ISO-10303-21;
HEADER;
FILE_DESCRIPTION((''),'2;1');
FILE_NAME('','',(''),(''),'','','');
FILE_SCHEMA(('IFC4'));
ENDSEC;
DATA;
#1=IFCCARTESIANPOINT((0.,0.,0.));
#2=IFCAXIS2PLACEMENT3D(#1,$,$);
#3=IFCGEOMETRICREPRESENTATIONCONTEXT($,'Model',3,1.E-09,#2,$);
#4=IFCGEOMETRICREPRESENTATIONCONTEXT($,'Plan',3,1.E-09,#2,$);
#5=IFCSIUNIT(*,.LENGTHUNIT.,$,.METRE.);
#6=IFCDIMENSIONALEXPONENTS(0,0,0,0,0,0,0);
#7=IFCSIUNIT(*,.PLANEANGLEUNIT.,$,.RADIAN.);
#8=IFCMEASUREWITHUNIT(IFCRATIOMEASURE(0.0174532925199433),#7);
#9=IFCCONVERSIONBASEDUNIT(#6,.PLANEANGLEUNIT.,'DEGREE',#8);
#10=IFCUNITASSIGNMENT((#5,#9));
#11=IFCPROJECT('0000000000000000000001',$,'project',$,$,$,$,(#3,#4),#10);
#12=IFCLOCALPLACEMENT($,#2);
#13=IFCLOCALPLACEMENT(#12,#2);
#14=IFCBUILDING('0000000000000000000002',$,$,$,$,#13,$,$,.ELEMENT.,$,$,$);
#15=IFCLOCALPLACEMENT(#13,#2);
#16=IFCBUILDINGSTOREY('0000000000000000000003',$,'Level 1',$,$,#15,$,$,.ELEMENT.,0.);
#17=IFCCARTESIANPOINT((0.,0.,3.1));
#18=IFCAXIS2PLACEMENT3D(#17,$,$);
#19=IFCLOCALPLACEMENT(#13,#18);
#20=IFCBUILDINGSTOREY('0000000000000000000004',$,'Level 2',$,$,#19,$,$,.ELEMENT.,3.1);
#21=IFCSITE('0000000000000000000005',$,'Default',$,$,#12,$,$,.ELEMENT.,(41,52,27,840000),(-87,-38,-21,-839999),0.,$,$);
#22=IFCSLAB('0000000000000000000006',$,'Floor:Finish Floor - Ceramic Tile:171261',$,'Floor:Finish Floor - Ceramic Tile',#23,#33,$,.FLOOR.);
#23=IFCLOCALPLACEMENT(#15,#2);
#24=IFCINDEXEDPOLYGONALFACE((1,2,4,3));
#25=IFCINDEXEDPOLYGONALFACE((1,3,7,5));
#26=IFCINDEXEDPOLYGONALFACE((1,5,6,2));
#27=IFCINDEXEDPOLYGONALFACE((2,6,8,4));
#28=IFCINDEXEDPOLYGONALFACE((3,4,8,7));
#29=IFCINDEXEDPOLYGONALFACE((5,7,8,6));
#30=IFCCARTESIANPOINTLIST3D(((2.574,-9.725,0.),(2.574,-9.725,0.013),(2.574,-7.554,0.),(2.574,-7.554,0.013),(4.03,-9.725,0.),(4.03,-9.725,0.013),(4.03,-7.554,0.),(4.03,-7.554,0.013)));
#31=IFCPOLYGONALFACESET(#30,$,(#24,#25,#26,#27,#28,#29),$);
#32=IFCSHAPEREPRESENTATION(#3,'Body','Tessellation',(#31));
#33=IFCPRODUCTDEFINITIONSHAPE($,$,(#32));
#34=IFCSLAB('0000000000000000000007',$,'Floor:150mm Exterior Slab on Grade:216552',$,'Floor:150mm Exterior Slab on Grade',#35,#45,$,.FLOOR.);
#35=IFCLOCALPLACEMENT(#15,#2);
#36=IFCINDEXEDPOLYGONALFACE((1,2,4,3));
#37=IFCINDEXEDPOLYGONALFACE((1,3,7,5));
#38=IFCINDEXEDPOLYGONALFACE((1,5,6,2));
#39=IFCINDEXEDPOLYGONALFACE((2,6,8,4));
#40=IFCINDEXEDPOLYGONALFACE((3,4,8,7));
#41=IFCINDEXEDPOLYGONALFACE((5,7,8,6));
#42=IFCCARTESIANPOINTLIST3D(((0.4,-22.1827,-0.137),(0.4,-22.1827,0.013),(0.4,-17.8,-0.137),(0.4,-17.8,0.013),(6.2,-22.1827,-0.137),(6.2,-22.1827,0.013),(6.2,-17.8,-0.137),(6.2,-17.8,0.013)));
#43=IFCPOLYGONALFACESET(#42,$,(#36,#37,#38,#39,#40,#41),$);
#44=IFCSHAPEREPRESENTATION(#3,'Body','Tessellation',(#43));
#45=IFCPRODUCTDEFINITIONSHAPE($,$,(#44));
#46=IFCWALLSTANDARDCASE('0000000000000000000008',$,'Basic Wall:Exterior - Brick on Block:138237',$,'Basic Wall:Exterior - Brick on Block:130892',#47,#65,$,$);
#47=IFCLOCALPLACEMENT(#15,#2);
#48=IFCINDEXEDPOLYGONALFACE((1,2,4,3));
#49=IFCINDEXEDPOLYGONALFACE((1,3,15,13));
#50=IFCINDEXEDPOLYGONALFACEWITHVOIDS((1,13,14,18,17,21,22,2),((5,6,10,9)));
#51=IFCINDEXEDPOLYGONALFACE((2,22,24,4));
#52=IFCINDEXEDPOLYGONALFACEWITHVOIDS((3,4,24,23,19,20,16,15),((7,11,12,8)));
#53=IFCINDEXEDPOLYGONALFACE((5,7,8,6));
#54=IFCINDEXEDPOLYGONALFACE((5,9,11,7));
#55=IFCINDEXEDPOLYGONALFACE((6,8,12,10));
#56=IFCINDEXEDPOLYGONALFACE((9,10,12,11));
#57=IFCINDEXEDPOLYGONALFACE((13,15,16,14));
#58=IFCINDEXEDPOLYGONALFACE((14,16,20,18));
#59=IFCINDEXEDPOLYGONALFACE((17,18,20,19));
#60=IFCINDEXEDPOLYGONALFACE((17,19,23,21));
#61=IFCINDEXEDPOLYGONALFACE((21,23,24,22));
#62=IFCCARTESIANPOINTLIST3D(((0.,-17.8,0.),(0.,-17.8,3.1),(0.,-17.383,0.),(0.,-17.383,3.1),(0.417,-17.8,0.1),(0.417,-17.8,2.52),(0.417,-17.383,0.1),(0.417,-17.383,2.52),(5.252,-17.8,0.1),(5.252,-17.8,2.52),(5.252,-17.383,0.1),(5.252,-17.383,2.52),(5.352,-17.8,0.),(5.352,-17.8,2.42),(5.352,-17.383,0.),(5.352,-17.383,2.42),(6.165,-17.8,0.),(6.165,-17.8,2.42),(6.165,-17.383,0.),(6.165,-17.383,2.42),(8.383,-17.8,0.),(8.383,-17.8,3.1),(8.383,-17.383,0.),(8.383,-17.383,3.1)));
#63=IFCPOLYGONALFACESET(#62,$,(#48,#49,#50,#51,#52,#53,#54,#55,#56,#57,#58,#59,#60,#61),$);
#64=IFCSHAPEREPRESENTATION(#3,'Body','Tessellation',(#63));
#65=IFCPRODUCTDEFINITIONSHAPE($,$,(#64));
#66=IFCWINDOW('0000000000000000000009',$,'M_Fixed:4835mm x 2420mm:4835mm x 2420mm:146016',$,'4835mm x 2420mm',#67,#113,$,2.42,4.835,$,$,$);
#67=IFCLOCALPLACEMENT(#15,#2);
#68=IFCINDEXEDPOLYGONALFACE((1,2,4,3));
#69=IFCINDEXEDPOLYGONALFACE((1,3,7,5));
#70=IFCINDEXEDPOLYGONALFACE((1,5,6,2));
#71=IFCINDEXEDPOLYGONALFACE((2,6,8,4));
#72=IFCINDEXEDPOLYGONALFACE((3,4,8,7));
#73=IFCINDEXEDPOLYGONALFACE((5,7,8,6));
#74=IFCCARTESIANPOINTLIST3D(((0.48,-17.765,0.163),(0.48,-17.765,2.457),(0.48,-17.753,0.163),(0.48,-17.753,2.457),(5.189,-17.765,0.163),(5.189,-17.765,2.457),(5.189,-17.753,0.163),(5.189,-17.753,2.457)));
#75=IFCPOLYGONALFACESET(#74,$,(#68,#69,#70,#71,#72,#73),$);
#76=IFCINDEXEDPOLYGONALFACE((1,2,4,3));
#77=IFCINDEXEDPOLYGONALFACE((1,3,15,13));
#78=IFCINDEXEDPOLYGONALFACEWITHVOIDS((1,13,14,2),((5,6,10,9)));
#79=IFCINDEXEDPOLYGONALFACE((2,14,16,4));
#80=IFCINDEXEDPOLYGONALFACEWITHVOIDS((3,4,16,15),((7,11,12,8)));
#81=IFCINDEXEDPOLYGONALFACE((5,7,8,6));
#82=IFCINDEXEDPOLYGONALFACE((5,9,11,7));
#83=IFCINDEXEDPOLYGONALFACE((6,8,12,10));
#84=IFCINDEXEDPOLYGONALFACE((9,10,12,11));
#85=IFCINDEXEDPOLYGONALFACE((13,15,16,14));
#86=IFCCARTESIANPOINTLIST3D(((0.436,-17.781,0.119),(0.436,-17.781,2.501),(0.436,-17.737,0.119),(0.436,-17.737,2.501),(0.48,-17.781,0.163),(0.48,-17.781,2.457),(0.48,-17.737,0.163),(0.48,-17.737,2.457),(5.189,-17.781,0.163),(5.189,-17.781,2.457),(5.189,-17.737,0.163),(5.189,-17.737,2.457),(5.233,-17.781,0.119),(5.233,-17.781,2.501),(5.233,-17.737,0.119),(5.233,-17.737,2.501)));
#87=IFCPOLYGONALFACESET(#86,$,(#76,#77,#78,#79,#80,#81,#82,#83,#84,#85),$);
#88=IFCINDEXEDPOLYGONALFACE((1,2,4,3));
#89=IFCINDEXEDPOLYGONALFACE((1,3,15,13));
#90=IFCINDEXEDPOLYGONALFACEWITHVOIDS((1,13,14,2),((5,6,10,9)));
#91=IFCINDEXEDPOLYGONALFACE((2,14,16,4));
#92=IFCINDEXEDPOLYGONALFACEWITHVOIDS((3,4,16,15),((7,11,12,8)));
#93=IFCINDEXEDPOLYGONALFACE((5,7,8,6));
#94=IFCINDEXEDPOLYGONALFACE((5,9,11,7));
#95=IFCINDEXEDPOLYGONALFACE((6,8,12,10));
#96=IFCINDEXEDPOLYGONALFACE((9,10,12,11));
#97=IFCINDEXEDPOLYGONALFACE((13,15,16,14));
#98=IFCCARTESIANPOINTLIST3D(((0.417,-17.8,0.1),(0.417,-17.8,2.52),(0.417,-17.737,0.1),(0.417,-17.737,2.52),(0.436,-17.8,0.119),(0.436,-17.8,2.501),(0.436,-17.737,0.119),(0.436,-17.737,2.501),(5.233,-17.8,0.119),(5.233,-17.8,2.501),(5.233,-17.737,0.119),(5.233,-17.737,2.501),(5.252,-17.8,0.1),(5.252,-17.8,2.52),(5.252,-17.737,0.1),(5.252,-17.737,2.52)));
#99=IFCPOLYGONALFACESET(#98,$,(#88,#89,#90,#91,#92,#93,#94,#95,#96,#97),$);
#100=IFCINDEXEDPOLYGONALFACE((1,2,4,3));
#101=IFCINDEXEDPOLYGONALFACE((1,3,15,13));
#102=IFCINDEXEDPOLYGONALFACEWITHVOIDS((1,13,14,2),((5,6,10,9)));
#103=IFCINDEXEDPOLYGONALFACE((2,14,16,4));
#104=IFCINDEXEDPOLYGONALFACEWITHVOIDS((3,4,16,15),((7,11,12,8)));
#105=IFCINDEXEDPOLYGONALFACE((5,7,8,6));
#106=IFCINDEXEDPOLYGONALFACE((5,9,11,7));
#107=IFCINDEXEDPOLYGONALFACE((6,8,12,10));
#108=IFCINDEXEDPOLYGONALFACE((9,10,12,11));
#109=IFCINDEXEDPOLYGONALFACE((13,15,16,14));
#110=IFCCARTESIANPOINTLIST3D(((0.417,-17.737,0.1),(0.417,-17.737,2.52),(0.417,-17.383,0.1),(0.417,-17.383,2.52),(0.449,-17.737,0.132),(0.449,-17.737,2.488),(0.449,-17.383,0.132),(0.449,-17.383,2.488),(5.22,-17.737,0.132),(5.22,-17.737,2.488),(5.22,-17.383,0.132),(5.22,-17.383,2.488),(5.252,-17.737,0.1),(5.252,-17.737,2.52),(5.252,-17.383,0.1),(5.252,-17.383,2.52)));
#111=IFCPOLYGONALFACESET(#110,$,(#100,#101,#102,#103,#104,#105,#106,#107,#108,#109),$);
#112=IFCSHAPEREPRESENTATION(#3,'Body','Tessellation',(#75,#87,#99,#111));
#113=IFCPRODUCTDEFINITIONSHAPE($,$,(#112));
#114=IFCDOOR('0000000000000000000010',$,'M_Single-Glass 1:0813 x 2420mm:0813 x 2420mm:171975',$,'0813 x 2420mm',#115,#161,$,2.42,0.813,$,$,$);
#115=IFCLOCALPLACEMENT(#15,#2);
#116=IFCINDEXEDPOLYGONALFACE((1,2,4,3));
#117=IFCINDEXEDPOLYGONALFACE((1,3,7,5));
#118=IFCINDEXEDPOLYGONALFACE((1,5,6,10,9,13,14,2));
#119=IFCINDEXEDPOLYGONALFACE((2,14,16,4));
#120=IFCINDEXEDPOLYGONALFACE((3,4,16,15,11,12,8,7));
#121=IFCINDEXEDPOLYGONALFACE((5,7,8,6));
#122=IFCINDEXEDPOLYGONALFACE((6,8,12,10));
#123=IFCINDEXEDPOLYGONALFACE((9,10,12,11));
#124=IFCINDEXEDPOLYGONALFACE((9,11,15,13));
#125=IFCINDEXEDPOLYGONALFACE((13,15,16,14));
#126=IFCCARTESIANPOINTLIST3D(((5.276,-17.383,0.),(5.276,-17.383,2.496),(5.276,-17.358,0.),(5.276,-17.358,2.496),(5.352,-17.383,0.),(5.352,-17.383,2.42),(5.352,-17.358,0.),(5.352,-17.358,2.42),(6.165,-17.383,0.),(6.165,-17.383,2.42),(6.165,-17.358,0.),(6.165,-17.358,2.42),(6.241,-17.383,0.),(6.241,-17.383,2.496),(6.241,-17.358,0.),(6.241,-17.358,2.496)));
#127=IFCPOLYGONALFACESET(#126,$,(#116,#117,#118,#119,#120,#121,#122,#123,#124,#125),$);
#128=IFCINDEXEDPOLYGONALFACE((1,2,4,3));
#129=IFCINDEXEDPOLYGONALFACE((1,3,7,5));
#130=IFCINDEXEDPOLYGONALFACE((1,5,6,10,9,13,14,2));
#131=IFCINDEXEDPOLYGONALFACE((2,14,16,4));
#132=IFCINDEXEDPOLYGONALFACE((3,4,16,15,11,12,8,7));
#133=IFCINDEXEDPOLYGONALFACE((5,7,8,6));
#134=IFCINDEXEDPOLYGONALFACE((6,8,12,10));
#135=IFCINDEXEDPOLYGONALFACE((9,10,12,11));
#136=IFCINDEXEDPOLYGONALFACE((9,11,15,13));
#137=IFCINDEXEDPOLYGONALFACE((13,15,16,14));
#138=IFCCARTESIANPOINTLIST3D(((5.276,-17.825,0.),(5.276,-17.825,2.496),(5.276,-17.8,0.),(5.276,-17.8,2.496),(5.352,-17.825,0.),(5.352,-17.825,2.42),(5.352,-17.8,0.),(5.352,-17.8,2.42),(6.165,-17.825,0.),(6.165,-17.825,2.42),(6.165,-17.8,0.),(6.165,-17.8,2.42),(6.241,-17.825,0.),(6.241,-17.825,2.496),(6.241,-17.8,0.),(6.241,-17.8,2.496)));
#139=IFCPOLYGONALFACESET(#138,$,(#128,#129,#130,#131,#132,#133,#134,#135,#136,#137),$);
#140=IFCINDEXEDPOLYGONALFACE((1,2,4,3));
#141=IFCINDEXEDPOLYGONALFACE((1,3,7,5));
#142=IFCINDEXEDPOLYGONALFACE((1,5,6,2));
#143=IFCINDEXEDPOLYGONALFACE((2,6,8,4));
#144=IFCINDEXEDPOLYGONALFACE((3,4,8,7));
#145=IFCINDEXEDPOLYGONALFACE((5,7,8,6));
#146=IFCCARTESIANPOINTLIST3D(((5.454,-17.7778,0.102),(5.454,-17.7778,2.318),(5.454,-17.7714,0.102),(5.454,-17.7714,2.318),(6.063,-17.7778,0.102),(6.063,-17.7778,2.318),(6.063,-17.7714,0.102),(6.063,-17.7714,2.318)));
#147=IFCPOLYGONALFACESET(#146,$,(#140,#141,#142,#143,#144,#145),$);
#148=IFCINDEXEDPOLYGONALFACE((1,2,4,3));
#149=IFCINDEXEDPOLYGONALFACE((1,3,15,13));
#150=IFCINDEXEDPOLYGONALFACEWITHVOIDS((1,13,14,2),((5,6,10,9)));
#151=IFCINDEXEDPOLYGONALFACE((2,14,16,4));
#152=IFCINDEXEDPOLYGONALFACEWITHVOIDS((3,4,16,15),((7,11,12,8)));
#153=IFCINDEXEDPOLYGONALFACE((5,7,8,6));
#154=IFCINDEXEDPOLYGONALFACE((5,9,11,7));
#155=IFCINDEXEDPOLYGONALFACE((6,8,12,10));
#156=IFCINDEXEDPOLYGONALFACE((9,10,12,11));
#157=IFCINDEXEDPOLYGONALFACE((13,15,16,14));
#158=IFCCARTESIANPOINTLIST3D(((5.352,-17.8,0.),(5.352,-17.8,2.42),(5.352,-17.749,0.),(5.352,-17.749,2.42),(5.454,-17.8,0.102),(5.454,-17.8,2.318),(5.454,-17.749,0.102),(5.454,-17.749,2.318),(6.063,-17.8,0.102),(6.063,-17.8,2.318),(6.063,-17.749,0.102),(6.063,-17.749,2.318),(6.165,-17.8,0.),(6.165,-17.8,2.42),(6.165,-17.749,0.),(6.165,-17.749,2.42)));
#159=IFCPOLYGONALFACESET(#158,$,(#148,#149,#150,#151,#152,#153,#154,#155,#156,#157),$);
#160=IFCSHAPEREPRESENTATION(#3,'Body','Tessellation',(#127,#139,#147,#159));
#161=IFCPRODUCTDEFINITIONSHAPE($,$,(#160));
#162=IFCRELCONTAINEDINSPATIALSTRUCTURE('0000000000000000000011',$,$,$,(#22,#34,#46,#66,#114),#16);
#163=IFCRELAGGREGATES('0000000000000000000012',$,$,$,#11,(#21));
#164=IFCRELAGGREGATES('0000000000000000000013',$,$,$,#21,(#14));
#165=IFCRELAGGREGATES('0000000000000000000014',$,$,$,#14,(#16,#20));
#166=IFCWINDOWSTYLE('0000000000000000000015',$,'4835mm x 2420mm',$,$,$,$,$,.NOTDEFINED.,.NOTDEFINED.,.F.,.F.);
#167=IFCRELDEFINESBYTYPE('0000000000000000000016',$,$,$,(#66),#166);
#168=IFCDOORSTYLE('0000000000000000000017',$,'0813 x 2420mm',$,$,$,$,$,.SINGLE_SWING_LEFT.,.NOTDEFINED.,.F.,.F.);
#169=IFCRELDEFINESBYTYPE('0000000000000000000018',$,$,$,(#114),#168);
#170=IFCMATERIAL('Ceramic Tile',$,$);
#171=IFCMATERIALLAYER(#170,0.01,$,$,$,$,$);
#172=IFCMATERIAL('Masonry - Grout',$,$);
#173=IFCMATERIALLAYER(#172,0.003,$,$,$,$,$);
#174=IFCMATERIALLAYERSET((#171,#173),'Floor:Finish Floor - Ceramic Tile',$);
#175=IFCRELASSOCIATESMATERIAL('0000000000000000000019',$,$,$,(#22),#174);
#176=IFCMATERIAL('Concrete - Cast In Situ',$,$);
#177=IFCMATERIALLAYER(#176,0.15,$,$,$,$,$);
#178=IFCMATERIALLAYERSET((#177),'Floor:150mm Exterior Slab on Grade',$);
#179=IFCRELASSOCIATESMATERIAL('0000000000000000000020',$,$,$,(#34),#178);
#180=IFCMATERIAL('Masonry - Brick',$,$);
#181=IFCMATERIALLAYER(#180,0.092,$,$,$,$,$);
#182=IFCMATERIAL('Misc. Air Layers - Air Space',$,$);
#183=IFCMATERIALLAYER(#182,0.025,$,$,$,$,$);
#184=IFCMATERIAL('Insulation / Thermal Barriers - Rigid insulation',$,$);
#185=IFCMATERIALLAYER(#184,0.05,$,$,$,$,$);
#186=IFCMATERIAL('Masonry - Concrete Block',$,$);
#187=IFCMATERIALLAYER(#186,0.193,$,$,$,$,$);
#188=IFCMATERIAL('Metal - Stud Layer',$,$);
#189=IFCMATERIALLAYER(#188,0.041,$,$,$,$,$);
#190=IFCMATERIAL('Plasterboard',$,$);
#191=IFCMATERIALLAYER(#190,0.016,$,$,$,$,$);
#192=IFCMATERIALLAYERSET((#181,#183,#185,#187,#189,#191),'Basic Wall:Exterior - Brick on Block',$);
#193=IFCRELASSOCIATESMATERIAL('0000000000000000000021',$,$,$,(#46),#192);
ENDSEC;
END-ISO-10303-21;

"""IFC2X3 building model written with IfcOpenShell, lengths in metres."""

from ifc_helpers import new_model, entity, si_unit, converted_unit, frame, frame_2d, origin, origin_2d_with_axis, place, context, project, spatial, polyline, rectangle, outline, extrude, source, transform, mapped, material, layer, layer_set, layer_usage, type_object, type_shapes, element, fill, save


model = new_model("IFC2X3")

# Units and contexts
model_context = context("Model", 3, precision=1e-09, world=origin())
plan_context = context("Plan", 3, precision=1e-09, world=origin())
ifc_project = project(units=[si_unit("LENGTHUNIT", "METRE"), converted_unit("PLANEANGLEUNIT", "DEGREE", entity("IfcRatioMeasure", 0.0174532925199433), si_unit("PLANEANGLEUNIT", "RADIAN"), dimensions=[0, 0, 0, 0, 0, 0, 0])], contexts=[model_context, plan_context])

# Site, building, storey
site_placement = place(None, origin())
site = spatial("IfcSite", under=ifc_project, at=site_placement, Name="Default", CompositionType="ELEMENT", RefLatitude=(41, 52, 27, 840000), RefLongitude=(-87, -38, -21, -839999), RefElevation=0.0)
building_placement = place(site_placement, origin())
building = spatial("IfcBuilding", under=site, at=building_placement, CompositionType="ELEMENT")
storey_1_placement = place(building_placement, origin())
storey_1 = spatial("IfcBuildingStorey", under=building, at=storey_1_placement, Name="Level 1", CompositionType="ELEMENT", Elevation=0.0)

# Slabs
ifc_material_1 = material(Name="Ceramic Tile")
ifc_layer_1 = layer(ifc_material_1, 0.01)
ifc_material_2 = material(Name="Masonry - Grout")
ifc_layer_2 = layer(ifc_material_2, 0.003)
ifc_layer_set_1 = layer_set([ifc_layer_1, ifc_layer_2], Name="Floor:Finish Floor - Ceramic Tile")
ifc_layer_usage_1 = layer_usage(ifc_layer_set_1, "AXIS3", "POSITIVE", 0.0)
slab_1_placement = place(storey_1_placement, frame((2.574, -9.725, 0.0)))
element("IfcSlab", 1, at=slab_1_placement, inside=storey_1, material=ifc_layer_usage_1, Name="Floor:Finish Floor - Ceramic Tile:171261", ObjectType="Floor:Finish Floor - Ceramic Tile", PredefinedType="FLOOR", context=model_context, shape_type="SweptSolid", body=[
    extrude(rectangle(XDim=2.171, YDim=1.456, at=frame_2d((0.0, 0.0), x_axis=(0.0, -1.0))), frame((0.728, 1.0855, 0.013), z_axis=(0.0, 0.0, -1.0), x_axis=(-1.0, 0.0, 0.0)), (0.0, 0.0, 1.0), 0.013),
])
ifc_material_3 = material(Name="Concrete - Cast In Situ")
ifc_layer_3 = layer(ifc_material_3, 0.15)
ifc_layer_set_2 = layer_set([ifc_layer_3], Name="Floor:150mm Exterior Slab on Grade")
ifc_layer_usage_2 = layer_usage(ifc_layer_set_2, "AXIS3", "POSITIVE", 0.0)
slab_2_placement = place(storey_1_placement, frame((0.4, -22.1827, -0.137)))
element("IfcSlab", 2, at=slab_2_placement, inside=storey_1, material=ifc_layer_usage_2, Name="Floor:150mm Exterior Slab on Grade:216552", ObjectType="Floor:150mm Exterior Slab on Grade", PredefinedType="FLOOR", context=model_context, shape_type="SweptSolid", body=[
    extrude(rectangle(XDim=5.8, YDim=4.3827, at=origin_2d_with_axis()), frame((2.9, 2.1914, 0.15), z_axis=(0.0, 0.0, -1.0), x_axis=(-1.0, 0.0, 0.0)), (0.0, 0.0, 1.0), 0.15),
])

# Wall, openings, window, door
ifc_material_4 = material(Name="Masonry - Brick")
ifc_layer_4 = layer(ifc_material_4, 0.092)
ifc_material_5 = material(Name="Misc. Air Layers - Air Space")
ifc_layer_5 = layer(ifc_material_5, 0.025)
ifc_material_6 = material(Name="Insulation / Thermal Barriers - Rigid insulation")
ifc_layer_6 = layer(ifc_material_6, 0.05)
ifc_material_7 = material(Name="Masonry - Concrete Block")
ifc_layer_7 = layer(ifc_material_7, 0.193)
ifc_material_8 = material(Name="Metal - Stud Layer")
ifc_layer_8 = layer(ifc_material_8, 0.041)
ifc_material_9 = material(Name="Plasterboard")
ifc_layer_9 = layer(ifc_material_9, 0.016)
ifc_layer_set_3 = layer_set([ifc_layer_4, ifc_layer_5, ifc_layer_6, ifc_layer_7, ifc_layer_8, ifc_layer_9], Name="Basic Wall:Exterior - Brick on Block")
ifc_layer_usage_3 = layer_usage(ifc_layer_set_3, "AXIS2", "NEGATIVE", 0.2085)
wall_1_placement = place(storey_1_placement, frame((8.383, -17.5915, 0.0), z_axis=(0.0, 0.0, 1.0), x_axis=(-1.0, 0.0, 0.0)))
wall_1 = element("IfcWallStandardCase", 3, at=wall_1_placement, inside=storey_1, material=ifc_layer_usage_3, Name="Basic Wall:Exterior - Brick on Block:138237", ObjectType="Basic Wall:Exterior - Brick on Block:130892", context=model_context, shape_type="SweptSolid", body=[
    extrude(rectangle(XDim=8.383, YDim=0.417, at=frame_2d((4.1915, 0.0), x_axis=(-1.0, 0.0))), origin(), (0.0, 0.0, 1.0), 3.1),
])
opening_1_placement = place(wall_1_placement, frame((3.131, -0.2085, 0.1)))
opening_1 = element("IfcOpeningElement", 4, at=opening_1_placement, cuts=wall_1, ObjectType="Opening", context=model_context, shape_type="SweptSolid", body=[
    extrude(rectangle(XDim=2.42, YDim=4.835, at=frame_2d((1.21, 2.4175), x_axis=(1.0, 0.0))), frame((0.0, 0.0, 0.0), z_axis=(0.0, 1.0, 0.0), x_axis=(0.0, 0.0, 1.0)), (0.0, 0.0, 1.0), 0.417),
])
opening_2_placement = place(wall_1_placement, frame((2.218, -0.2085, 0.0)))
opening_2 = element("IfcOpeningElement", 5, at=opening_2_placement, cuts=wall_1, ObjectType="Opening", context=model_context, shape_type="SweptSolid", body=[
    extrude(rectangle(XDim=0.813, YDim=2.42, at=frame_2d((1.21, 0.4065), x_axis=(0.0, -1.0))), frame((0.0, 0.0, 0.0), z_axis=(0.0, 1.0, 0.0), x_axis=(0.0, 0.0, 1.0)), (0.0, 0.0, 1.0), 0.417),
])
window_style_1 = type_object("IfcWindowStyle", Name="4835mm x 2420mm", ConstructionType="NOTDEFINED", OperationType="NOTDEFINED", ParameterTakesPrecedence=False, Sizeable=False)
shared_shape_1 = source(origin(), model_context, "Body", "SweptSolid", [
    extrude(rectangle(XDim=0.012, YDim=4.709, at=origin_2d_with_axis()), frame((2.4175, 0.376, 0.063), z_axis=(0.0, 0.0, 1.0), x_axis=(0.0, -1.0, 0.0)), (0.0, 0.0, 1.0), 2.294),
    extrude(outline(polyline([(-2.3985, -1.191), (2.3985, -1.191), (2.3985, 1.191), (-2.3985, 1.191), (-2.3985, -1.191)]), holes=[polyline([(-2.3545, -1.147), (-2.3545, 1.147), (2.3545, 1.147), (2.3545, -1.147), (-2.3545, -1.147)])]), frame((2.4175, 0.354, 1.21), z_axis=(0.0, 1.0, 0.0), x_axis=(1.0, 0.0, 0.0)), (0.0, 0.0, 1.0), 0.044),
    extrude(outline(polyline([(-2.4175, -1.21), (2.4175, -1.21), (2.4175, 1.21), (-2.4175, 1.21), (-2.4175, -1.21)]), holes=[polyline([(-2.3985, -1.191), (-2.3985, 1.191), (2.3985, 1.191), (2.3985, -1.191), (-2.3985, -1.191)])]), frame((2.4175, 0.354, 1.21), z_axis=(0.0, 1.0, 0.0), x_axis=(1.0, 0.0, 0.0)), (0.0, 0.0, 1.0), 0.063),
    extrude(outline(polyline([(-2.4175, -1.21), (2.4175, -1.21), (2.4175, 1.21), (-2.4175, 1.21), (-2.4175, -1.21)]), holes=[polyline([(-2.3855, -1.178), (-2.3855, 1.178), (2.3855, 1.178), (2.3855, -1.178), (-2.3855, -1.178)])]), frame((2.4175, 0.0, 1.21), z_axis=(0.0, 1.0, 0.0), x_axis=(1.0, 0.0, 0.0)), (0.0, 0.0, 1.0), 0.354),
])
type_shapes(window_style_1, [shared_shape_1])
window_1_placement = place(opening_1_placement, origin())
window_1 = element("IfcWindow", 6, at=window_1_placement, inside=storey_1, type_object=window_style_1, Name="M_Fixed:4835mm x 2420mm:4835mm x 2420mm:146016", ObjectType="4835mm x 2420mm", OverallHeight=2.42, OverallWidth=4.835, context=model_context, shape_type="MappedRepresentation", body=[
    mapped(shared_shape_1, transform((0.0, 0.0, 0.0), scale=1.0)),
])
fill(opening_1, window_1)
door_style_1 = type_object("IfcDoorStyle", Name="0813 x 2420mm", ConstructionType="NOTDEFINED", OperationType="SINGLE_SWING_LEFT", ParameterTakesPrecedence=False, Sizeable=False)
shared_shape_2 = source(origin(), model_context, "Body", "SweptSolid", [
    extrude(outline(polyline([(-0.4065, -1.191), (-0.4065, 1.229), (-0.4825, 1.229), (-0.4825, -1.267), (0.4825, -1.267), (0.4825, 1.229), (0.4065, 1.229), (0.4065, -1.191), (-0.4065, -1.191)])), frame((0.4065, 0.0, 1.229), z_axis=(0.0, 1.0, 0.0), x_axis=(1.0, 0.0, 0.0)), (0.0, 0.0, -1.0), 0.025),
    extrude(outline(polyline([(-0.4065, -1.191), (-0.4065, 1.229), (-0.4825, 1.229), (-0.4825, -1.267), (0.4825, -1.267), (0.4825, 1.229), (0.4065, 1.229), (0.4065, -1.191), (-0.4065, -1.191)])), frame((0.4065, 0.442, 1.229), z_axis=(0.0, 1.0, 0.0), x_axis=(1.0, 0.0, 0.0)), (0.0, 0.0, -1.0), 0.025),
    extrude(rectangle(XDim=0.609, YDim=0.0064, at=origin_2d_with_axis()), frame((0.4065, 0.3916, 0.102)), (0.0, 0.0, 1.0), 2.216),
    extrude(outline(polyline([(-1.21, -0.4065), (1.21, -0.4065), (1.21, 0.4065), (-1.21, 0.4065), (-1.21, -0.4065)]), holes=[polyline([(-1.108, 0.3045), (1.108, 0.3045), (1.108, -0.3045), (-1.108, -0.3045), (-1.108, 0.3045)])]), frame((0.4065, 0.417, 1.21), z_axis=(0.0, -1.0, 0.0), x_axis=(0.0, 0.0, -1.0)), (0.0, 0.0, 1.0), 0.051),
])
type_shapes(door_style_1, [shared_shape_2])
door_1_placement = place(opening_2_placement, origin())
door_1 = element("IfcDoor", 7, at=door_1_placement, inside=storey_1, type_object=door_style_1, Name="M_Single-Glass 1:0813 x 2420mm:0813 x 2420mm:171975", ObjectType="0813 x 2420mm", OverallHeight=2.42, OverallWidth=0.813, context=model_context, shape_type="MappedRepresentation", body=[
    mapped(shared_shape_2, transform((0.0, 0.0, 0.0), scale=1.0)),
])
fill(opening_2, door_1)

# Shared definitions
storey_2_placement = place(building_placement, frame((0.0, 0.0, 3.1)))
storey_2 = spatial("IfcBuildingStorey", under=building, at=storey_2_placement, Name="Level 2", CompositionType="ELEMENT", Elevation=3.1)

save(model, "model.ifc")
